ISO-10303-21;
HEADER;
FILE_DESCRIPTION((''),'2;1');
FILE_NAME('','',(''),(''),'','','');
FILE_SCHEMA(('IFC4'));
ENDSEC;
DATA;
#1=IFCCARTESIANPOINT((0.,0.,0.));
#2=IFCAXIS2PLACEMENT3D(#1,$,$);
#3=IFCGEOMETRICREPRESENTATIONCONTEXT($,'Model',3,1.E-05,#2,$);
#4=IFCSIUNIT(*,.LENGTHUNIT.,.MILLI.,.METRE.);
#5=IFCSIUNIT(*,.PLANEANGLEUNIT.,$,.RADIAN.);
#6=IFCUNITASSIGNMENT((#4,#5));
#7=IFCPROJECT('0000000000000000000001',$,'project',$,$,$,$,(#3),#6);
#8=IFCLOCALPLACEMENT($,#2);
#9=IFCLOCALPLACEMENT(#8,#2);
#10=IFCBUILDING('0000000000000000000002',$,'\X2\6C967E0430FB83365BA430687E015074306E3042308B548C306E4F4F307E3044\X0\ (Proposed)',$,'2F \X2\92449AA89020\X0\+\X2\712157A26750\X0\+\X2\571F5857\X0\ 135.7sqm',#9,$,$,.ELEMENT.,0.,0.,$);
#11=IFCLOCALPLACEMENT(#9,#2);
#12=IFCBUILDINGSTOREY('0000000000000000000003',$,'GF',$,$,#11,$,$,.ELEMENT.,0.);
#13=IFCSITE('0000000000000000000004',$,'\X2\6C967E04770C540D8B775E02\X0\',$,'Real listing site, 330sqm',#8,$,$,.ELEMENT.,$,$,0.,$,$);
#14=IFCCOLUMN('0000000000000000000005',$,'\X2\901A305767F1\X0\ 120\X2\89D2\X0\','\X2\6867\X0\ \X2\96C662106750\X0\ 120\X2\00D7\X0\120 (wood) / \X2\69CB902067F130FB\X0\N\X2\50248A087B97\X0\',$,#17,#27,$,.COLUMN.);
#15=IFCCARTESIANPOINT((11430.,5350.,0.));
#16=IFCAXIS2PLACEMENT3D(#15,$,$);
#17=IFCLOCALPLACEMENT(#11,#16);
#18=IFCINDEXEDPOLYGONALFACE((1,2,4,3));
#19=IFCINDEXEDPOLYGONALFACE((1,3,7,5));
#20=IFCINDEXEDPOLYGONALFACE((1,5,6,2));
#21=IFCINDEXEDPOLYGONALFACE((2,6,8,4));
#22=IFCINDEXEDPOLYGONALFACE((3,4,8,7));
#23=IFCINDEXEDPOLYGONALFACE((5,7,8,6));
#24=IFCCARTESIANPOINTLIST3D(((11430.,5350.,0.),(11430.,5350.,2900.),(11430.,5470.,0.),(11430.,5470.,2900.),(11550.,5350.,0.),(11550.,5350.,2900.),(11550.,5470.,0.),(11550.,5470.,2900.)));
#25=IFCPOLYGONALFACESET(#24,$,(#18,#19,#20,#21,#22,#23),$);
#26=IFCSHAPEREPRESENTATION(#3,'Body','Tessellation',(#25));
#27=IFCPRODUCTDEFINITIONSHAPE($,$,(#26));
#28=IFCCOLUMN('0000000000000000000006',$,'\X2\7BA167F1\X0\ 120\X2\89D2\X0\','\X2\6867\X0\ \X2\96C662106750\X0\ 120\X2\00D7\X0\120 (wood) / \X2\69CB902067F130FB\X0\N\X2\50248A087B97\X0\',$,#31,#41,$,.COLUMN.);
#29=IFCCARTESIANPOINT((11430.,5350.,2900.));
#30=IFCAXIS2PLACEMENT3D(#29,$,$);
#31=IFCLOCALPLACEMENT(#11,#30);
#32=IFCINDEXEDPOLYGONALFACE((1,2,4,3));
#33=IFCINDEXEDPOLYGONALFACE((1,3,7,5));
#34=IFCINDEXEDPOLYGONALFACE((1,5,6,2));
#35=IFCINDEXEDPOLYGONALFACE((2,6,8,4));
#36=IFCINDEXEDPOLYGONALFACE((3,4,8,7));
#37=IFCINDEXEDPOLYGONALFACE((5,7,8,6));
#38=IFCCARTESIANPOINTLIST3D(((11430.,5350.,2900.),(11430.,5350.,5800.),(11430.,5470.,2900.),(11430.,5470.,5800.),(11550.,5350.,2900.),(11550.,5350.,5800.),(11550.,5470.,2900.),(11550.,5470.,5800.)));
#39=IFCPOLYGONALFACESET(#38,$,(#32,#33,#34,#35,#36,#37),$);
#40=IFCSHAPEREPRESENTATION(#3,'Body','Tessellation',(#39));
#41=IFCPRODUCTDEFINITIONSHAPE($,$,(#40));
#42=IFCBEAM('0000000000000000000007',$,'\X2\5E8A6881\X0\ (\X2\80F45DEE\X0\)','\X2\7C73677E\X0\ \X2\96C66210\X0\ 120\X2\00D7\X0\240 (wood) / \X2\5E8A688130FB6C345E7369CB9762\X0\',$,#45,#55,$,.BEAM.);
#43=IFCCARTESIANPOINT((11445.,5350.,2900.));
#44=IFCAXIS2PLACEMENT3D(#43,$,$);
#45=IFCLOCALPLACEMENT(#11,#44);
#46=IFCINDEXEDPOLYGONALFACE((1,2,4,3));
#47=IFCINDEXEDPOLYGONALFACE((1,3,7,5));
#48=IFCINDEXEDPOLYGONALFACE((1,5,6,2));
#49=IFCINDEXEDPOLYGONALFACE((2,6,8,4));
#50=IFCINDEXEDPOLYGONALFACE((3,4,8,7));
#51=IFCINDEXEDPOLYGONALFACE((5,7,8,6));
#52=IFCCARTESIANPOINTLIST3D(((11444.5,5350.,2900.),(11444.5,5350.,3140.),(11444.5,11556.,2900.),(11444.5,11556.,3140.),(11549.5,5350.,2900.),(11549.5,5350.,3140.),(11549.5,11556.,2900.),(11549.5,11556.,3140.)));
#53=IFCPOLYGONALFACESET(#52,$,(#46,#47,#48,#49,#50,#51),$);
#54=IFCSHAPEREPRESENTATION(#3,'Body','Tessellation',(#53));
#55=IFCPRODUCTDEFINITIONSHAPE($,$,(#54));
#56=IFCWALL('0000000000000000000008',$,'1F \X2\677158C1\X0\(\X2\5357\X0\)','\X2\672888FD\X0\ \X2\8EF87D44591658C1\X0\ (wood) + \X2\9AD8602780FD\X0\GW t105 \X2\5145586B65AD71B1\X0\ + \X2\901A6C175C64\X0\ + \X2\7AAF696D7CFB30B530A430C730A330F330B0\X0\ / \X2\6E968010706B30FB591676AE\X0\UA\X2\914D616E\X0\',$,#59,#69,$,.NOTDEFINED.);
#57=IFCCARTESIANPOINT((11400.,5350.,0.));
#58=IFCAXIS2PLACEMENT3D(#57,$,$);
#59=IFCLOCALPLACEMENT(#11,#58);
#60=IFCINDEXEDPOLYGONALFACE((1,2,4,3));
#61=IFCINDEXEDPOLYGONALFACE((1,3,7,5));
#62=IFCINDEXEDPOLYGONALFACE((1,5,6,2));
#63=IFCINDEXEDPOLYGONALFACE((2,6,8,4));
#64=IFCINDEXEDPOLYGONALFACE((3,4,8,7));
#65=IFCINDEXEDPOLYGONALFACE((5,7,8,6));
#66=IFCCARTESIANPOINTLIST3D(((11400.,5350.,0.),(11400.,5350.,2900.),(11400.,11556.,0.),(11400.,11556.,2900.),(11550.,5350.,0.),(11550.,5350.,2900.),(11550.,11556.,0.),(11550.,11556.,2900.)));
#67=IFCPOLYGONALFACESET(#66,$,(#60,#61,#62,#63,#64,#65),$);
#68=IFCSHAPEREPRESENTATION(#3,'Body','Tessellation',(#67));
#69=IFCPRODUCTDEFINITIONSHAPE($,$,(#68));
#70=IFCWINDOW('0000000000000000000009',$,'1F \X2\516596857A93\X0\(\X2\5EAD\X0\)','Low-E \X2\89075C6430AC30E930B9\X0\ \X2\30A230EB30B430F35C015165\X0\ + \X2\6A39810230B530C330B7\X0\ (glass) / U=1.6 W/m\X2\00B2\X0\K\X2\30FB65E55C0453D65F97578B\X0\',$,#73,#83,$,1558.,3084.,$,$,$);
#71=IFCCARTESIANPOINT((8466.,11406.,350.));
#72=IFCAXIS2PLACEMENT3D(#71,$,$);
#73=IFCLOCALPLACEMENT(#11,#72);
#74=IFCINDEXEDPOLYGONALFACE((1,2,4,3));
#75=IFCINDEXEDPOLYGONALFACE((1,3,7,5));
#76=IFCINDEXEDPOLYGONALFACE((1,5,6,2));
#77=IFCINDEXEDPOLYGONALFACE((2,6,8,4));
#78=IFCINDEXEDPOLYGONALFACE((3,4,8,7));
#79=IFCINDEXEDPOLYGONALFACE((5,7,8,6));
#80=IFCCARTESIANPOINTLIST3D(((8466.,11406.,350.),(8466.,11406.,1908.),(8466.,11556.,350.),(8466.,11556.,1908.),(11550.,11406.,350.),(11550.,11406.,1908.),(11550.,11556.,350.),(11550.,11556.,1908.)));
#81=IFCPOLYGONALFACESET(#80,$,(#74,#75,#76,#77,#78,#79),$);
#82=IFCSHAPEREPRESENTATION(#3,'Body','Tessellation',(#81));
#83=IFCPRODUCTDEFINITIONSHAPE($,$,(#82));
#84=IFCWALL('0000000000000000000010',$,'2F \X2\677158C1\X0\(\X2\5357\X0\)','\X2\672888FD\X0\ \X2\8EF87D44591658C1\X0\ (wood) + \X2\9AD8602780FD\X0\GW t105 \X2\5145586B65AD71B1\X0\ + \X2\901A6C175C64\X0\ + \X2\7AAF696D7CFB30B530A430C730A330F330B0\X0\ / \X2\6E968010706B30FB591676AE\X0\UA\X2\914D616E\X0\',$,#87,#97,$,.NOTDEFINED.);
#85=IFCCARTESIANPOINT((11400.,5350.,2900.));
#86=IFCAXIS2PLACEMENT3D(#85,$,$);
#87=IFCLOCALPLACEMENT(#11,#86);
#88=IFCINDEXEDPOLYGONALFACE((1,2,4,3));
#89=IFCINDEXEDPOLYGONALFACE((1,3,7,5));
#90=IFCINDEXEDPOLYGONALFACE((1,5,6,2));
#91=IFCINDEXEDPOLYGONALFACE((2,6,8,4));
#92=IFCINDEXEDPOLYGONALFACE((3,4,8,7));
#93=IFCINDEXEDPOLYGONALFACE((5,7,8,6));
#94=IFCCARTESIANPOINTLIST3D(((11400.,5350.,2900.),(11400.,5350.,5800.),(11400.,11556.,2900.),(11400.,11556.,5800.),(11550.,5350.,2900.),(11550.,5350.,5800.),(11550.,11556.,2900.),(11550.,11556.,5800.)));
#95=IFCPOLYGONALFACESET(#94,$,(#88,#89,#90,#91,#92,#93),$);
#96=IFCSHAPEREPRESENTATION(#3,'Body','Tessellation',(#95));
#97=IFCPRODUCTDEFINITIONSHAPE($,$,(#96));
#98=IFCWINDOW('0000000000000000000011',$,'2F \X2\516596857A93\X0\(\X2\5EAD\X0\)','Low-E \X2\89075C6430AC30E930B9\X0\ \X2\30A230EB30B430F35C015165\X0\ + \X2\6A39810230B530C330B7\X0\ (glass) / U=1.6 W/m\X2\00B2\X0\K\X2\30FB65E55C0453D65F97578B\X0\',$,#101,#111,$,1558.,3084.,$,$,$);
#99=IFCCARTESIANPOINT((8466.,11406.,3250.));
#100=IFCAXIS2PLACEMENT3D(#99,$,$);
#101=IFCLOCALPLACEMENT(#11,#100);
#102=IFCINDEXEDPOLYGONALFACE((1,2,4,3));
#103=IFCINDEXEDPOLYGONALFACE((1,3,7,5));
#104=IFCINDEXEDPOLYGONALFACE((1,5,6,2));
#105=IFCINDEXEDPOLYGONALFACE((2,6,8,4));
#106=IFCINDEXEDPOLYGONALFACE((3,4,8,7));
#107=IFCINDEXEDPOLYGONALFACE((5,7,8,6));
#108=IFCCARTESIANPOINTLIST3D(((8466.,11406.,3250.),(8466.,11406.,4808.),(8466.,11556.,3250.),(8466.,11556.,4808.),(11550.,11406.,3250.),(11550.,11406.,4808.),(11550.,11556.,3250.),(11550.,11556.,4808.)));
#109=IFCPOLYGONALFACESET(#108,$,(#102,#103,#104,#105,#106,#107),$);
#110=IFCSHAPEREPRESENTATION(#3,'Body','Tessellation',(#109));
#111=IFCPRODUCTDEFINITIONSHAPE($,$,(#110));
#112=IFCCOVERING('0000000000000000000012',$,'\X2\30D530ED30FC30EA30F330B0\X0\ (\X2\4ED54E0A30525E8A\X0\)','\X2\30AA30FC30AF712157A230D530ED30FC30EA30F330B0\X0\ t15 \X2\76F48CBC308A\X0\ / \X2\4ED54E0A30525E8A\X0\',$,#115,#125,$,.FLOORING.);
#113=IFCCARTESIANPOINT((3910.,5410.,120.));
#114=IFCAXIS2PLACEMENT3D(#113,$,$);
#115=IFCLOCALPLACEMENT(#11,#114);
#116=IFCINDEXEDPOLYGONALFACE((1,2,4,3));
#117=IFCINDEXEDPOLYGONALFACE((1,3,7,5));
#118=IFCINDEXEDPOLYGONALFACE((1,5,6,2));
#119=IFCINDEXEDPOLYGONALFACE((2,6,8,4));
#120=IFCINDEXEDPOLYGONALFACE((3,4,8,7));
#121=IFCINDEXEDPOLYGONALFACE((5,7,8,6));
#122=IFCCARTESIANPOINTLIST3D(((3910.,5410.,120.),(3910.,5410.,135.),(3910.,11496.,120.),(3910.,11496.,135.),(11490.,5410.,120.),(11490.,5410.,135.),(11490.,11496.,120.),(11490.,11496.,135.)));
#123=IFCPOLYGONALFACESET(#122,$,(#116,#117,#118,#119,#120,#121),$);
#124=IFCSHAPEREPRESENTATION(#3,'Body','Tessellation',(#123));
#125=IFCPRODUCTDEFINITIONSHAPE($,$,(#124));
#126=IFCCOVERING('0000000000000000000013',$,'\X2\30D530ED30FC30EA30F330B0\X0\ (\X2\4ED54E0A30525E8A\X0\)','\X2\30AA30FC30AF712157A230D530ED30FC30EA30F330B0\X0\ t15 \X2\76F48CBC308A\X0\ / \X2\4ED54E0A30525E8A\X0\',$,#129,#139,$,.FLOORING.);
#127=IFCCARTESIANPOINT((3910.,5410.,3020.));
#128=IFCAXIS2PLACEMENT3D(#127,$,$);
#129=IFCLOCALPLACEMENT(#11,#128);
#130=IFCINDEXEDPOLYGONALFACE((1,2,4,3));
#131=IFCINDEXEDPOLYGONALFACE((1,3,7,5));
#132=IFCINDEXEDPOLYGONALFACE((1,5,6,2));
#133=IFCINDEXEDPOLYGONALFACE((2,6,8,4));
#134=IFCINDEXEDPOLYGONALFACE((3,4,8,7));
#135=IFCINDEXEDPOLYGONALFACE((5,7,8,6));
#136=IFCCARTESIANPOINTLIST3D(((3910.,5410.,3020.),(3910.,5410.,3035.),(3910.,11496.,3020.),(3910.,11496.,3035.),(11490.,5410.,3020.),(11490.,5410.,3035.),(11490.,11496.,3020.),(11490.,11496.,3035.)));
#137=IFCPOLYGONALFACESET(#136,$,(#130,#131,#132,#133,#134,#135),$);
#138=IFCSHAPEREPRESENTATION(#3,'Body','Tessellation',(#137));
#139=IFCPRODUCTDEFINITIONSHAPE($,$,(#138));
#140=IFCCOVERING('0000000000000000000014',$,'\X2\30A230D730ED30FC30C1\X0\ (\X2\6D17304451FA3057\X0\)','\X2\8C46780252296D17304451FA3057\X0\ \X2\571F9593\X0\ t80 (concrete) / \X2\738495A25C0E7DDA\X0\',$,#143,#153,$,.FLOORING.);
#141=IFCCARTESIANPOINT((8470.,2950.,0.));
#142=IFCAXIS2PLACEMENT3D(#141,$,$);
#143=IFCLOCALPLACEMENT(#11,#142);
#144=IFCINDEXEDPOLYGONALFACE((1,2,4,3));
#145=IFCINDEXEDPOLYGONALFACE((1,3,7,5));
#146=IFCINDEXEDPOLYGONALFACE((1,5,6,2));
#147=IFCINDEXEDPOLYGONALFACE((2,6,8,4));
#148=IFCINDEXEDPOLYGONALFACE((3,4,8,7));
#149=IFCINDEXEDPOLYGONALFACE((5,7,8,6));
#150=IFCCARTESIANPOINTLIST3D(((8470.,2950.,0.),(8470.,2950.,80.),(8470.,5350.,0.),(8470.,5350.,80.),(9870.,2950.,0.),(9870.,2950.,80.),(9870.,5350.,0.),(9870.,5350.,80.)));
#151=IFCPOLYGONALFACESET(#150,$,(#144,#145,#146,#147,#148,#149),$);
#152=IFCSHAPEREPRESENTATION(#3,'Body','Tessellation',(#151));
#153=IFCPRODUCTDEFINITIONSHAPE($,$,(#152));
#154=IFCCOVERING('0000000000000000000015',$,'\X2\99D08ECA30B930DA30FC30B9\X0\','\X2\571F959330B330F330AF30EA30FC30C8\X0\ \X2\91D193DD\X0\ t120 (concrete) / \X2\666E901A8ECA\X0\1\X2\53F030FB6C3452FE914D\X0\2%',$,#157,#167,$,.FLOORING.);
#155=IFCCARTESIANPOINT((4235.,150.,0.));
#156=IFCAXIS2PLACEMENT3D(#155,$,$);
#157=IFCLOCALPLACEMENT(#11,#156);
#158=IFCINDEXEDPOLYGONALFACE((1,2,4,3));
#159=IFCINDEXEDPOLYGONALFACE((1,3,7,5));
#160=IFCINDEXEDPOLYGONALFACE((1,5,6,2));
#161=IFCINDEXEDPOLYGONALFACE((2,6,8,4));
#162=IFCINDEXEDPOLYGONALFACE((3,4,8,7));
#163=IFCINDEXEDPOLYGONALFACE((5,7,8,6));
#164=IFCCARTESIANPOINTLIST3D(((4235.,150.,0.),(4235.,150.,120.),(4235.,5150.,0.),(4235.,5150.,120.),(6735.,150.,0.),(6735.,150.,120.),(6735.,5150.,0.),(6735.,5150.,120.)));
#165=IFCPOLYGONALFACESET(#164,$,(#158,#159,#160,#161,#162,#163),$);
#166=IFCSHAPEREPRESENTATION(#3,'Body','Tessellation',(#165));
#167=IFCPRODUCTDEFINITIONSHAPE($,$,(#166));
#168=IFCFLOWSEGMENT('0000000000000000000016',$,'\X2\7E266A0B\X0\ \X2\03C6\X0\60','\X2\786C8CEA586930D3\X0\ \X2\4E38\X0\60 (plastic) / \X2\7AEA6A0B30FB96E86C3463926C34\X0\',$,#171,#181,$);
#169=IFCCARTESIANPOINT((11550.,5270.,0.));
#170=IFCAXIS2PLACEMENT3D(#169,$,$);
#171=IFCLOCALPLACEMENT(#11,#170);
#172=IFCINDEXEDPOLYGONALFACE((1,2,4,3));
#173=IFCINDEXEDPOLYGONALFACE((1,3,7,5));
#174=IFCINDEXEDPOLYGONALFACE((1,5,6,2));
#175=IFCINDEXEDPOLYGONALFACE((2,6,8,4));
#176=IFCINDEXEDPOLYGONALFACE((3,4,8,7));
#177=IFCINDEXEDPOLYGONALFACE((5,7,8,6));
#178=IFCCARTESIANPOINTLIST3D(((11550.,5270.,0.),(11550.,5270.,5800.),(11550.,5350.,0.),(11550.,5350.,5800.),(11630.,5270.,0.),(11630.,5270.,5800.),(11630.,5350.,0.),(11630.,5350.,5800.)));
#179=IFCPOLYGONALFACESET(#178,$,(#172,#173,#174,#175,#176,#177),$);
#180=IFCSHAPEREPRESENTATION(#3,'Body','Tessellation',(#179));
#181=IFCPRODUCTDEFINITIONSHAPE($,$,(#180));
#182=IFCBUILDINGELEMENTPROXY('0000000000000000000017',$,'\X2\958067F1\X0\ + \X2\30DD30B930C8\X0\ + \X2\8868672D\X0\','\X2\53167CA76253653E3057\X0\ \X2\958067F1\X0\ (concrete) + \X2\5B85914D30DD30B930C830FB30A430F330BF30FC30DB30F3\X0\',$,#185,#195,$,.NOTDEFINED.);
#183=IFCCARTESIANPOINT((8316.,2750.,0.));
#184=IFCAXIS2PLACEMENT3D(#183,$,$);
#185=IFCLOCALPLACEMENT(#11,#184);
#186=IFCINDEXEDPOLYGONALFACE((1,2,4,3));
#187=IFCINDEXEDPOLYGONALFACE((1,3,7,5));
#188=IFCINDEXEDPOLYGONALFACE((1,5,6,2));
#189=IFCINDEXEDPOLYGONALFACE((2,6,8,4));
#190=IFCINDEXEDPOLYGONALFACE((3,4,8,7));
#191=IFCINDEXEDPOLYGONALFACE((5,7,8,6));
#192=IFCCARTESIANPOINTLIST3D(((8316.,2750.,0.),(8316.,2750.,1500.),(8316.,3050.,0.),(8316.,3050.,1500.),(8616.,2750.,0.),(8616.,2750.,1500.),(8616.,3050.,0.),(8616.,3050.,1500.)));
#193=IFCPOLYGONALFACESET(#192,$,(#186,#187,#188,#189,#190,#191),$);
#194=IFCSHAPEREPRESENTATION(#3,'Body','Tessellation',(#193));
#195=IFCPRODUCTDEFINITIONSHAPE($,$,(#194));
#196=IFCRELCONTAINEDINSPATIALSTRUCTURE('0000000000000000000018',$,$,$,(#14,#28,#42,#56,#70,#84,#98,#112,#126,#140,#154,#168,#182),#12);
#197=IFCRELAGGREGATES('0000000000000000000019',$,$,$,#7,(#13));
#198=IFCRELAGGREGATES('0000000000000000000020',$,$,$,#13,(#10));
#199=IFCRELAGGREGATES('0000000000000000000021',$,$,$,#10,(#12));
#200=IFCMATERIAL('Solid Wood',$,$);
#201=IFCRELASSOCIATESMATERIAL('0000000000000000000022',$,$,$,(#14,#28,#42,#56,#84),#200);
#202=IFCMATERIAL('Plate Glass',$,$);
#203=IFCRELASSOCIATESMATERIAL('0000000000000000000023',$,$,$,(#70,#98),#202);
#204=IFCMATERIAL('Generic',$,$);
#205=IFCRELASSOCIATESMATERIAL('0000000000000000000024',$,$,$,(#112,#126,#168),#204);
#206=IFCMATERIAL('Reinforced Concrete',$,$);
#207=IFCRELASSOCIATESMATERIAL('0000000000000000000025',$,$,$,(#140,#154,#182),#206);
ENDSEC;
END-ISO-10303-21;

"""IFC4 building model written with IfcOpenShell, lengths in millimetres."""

from ifc_helpers import new_model, si_unit, frame, frame_2d, origin, place, context, project, spatial, rectangle, extrude, material, element, fill, save


model = new_model("IFC4")

# Units and contexts
model_context = context("Model", 3, precision=1e-05, world=origin())
ifc_project = project(units=[si_unit("LENGTHUNIT", "METRE", prefix="MILLI"), si_unit("PLANEANGLEUNIT", "RADIAN")], contexts=[model_context])

# Site, building, storey
site_placement = place(None, origin())
site = spatial("IfcSite", under=ifc_project, at=site_placement, Name="沖縄県名護市", ObjectType="Real listing site, 330sqm", CompositionType="ELEMENT", RefElevation=0.0)
building_placement = place(site_placement, origin())
building = spatial("IfcBuilding", under=site, at=building_placement, Name="沖縄・茶室と縁側のある和の住まい (Proposed)", ObjectType="2F 鉄骨造+無垢材+土塗 135.7sqm", CompositionType="ELEMENT", ElevationOfRefHeight=0.0, ElevationOfTerrain=0.0)
storey_placement = place(building_placement, origin())
storey = spatial("IfcBuildingStorey", under=building, at=storey_placement, Name="GF", CompositionType="ELEMENT", Elevation=0.0)

# Columns
ifc_material_1 = material(Name="Solid Wood")
column_1_placement = place(storey_placement, frame((11430.0, 5350.0, 0.0)))
element("IfcColumn", 1, at=column_1_placement, inside=storey, material=ifc_material_1, Name="通し柱 120角", Description="桧 集成材 120×120 (wood) / 構造柱・N値計算", PredefinedType="COLUMN", context=model_context, shape_type="SweptSolid", body=[
    extrude(rectangle(XDim=120.0, YDim=120.0, at=frame_2d((60.0, 60.0))), frame((11430.0, 5350.0, 0.0)), (0.0, 0.0, 1.0), 2900.0),
])
column_2_placement = place(storey_placement, frame((11430.0, 5350.0, 2900.0)))
element("IfcColumn", 2, at=column_2_placement, inside=storey, material=ifc_material_1, Name="管柱 120角", Description="桧 集成材 120×120 (wood) / 構造柱・N値計算", PredefinedType="COLUMN", context=model_context, shape_type="SweptSolid", body=[
    extrude(rectangle(XDim=120.0, YDim=120.0, at=frame_2d((60.0, 60.0))), frame((11430.0, 5350.0, 2900.0)), (0.0, 0.0, 1.0), 2900.0),
])

# Beam
beam_1_placement = place(storey_placement, frame((11445.0, 5350.0, 2900.0)))
element("IfcBeam", 3, at=beam_1_placement, inside=storey, material=ifc_material_1, Name="床梁 (胴差)", Description="米松 集成 120×240 (wood) / 床梁・水平構面", PredefinedType="BEAM", context=model_context, shape_type="SweptSolid", body=[
    extrude(rectangle(XDim=105.0, YDim=6206.0, at=frame_2d((52.0, 3103.0))), frame((11445.0, 5350.0, 2900.0)), (0.0, 0.0, 1.0), 240.0),
])

# Wall, opening, window
wall_1_placement = place(storey_placement, frame((11400.0, 5350.0, 0.0)))
wall_1 = element("IfcWall", 4, at=wall_1_placement, inside=storey, material=ifc_material_1, Name="1F 東壁(南)", Description="木製 軸組外壁 (wood) + 高性能GW t105 充填断熱 + 通気層 + 窯業系サイディング / 準耐火・外皮UA配慮", PredefinedType="NOTDEFINED", context=model_context, shape_type="SweptSolid", body=[
    extrude(rectangle(XDim=150.0, YDim=6206.0, at=frame_2d((75.0, 3103.0))), frame((11400.0, 5350.0, 0.0)), (0.0, 0.0, 1.0), 2900.0),
])
opening_1_placement = place(storey_placement, frame((8466.0, 11406.0, 350.0)))
opening_1 = element("IfcOpeningElement", 5, at=opening_1_placement, cuts=wall_1, PredefinedType="NOTDEFINED", context=model_context, shape_type="SweptSolid", body=[
    extrude(rectangle(XDim=3084.0, YDim=150.0, at=frame_2d((1542.0, 75.0))), frame((8466.0, 11406.0, 350.0)), (0.0, 0.0, 1.0), 1558.0),
])
ifc_material_2 = material(Name="Plate Glass")
window_1_placement = place(storey_placement, frame((8466.0, 11406.0, 350.0)))
window_1 = element("IfcWindow", 6, at=window_1_placement, inside=storey, material=ifc_material_2, Name="1F 入隅窓(庭)", Description="Low-E 複層ガラス アルゴン封入 + 樹脂サッシ (glass) / U=1.6 W/m²K・日射取得型", OverallHeight=1558.0, OverallWidth=3084.0, context=model_context, shape_type="SweptSolid", body=[
    extrude(rectangle(XDim=3084.0, YDim=150.0, at=frame_2d((1542.0, 75.0))), frame((8466.0, 11406.0, 350.0)), (0.0, 0.0, 1.0), 1558.0),
])
fill(opening_1, window_1)

# Wall, opening, window
wall_2_placement = place(storey_placement, frame((11400.0, 5350.0, 2900.0)))
wall_2 = element("IfcWall", 7, at=wall_2_placement, inside=storey, material=ifc_material_1, Name="2F 東壁(南)", Description="木製 軸組外壁 (wood) + 高性能GW t105 充填断熱 + 通気層 + 窯業系サイディング / 準耐火・外皮UA配慮", PredefinedType="NOTDEFINED", context=model_context, shape_type="SweptSolid", body=[
    extrude(rectangle(XDim=150.0, YDim=6206.0, at=frame_2d((75.0, 3103.0))), frame((11400.0, 5350.0, 2900.0)), (0.0, 0.0, 1.0), 2900.0),
])
opening_2_placement = place(storey_placement, frame((8466.0, 11406.0, 3250.0)))
opening_2 = element("IfcOpeningElement", 8, at=opening_2_placement, cuts=wall_2, PredefinedType="NOTDEFINED", context=model_context, shape_type="SweptSolid", body=[
    extrude(rectangle(XDim=3084.0, YDim=150.0, at=frame_2d((1542.0, 75.0))), frame((8466.0, 11406.0, 3250.0)), (0.0, 0.0, 1.0), 1558.0),
])
window_2_placement = place(storey_placement, frame((8466.0, 11406.0, 3250.0)))
window_2 = element("IfcWindow", 9, at=window_2_placement, inside=storey, material=ifc_material_2, Name="2F 入隅窓(庭)", Description="Low-E 複層ガラス アルゴン封入 + 樹脂サッシ (glass) / U=1.6 W/m²K・日射取得型", OverallHeight=1558.0, OverallWidth=3084.0, context=model_context, shape_type="SweptSolid", body=[
    extrude(rectangle(XDim=3084.0, YDim=150.0, at=frame_2d((1542.0, 75.0))), frame((8466.0, 11406.0, 3250.0)), (0.0, 0.0, 1.0), 1558.0),
])
fill(opening_2, window_2)

# Coverings
ifc_material_3 = material(Name="Generic")
covering_1_placement = place(storey_placement, frame((3910.0, 5410.0, 120.0)))
element("IfcCovering", 10, at=covering_1_placement, inside=storey, material=ifc_material_3, Name="フローリング (仕上げ床)", Description="オーク無垢フローリング t15 直貼り / 仕上げ床", PredefinedType="FLOORING", context=model_context, shape_type="SweptSolid", body=[
    extrude(rectangle(XDim=7580.0, YDim=6086.0, at=frame_2d((3790.0, 3043.0))), frame((3910.0, 5410.0, 120.0)), (0.0, 0.0, 1.0), 15.0),
])
covering_2_placement = place(storey_placement, frame((3910.0, 5410.0, 3020.0)))
element("IfcCovering", 11, at=covering_2_placement, inside=storey, material=ifc_material_3, Name="フローリング (仕上げ床)", Description="オーク無垢フローリング t15 直貼り / 仕上げ床", PredefinedType="FLOORING", context=model_context, shape_type="SweptSolid", body=[
    extrude(rectangle(XDim=7580.0, YDim=6086.0, at=frame_2d((3790.0, 3043.0))), frame((3910.0, 5410.0, 3020.0)), (0.0, 0.0, 1.0), 15.0),
])
ifc_material_4 = material(Name="Reinforced Concrete")
covering_3_placement = place(storey_placement, frame((8470.0, 2950.0, 0.0)))
element("IfcCovering", 12, at=covering_3_placement, inside=storey, material=ifc_material_4, Name="アプローチ (洗い出し)", Description="豆砂利洗い出し 土間 t80 (concrete) / 玄関導線", PredefinedType="FLOORING", context=model_context, shape_type="SweptSolid", body=[
    extrude(rectangle(XDim=1400.0, YDim=2400.0, at=frame_2d((700.0, 1200.0))), frame((8470.0, 2950.0, 0.0)), (0.0, 0.0, 1.0), 80.0),
])
covering_4_placement = place(storey_placement, frame((4235.0, 150.0, 0.0)))
element("IfcCovering", 13, at=covering_4_placement, inside=storey, material=ifc_material_4, Name="駐車スペース", Description="土間コンクリート 金鏝 t120 (concrete) / 普通車1台・水勾配2%", PredefinedType="FLOORING", context=model_context, shape_type="SweptSolid", body=[
    extrude(rectangle(XDim=2500.0, YDim=5000.0, at=frame_2d((1250.0, 2500.0))), frame((4235.0, 150.0, 0.0)), (0.0, 0.0, 1.0), 120.0),
])

# Flow segment
flow_segment_placement = place(storey_placement, frame((11550.0, 5270.0, 0.0)))
element("IfcFlowSegment", 14, at=flow_segment_placement, inside=storey, material=ifc_material_3, Name="縦樋 φ60", Description="硬質塩ビ 丸60 (plastic) / 竪樋・雨水排水", context=model_context, shape_type="SweptSolid", body=[
    extrude(rectangle(XDim=80.0, YDim=80.0, at=frame_2d((40.0, 40.0))), frame((11550.0, 5270.0, 0.0)), (0.0, 0.0, 1.0), 5800.0),
])

# Building element proxy
proxy_placement = place(storey_placement, frame((8316.0, 2750.0, 0.0)))
element("IfcBuildingElementProxy", 15, at=proxy_placement, inside=storey, material=ifc_material_4, Name="門柱 + ポスト + 表札", Description="化粧打放し 門柱 (concrete) + 宅配ポスト・インターホン", PredefinedType="NOTDEFINED", context=model_context, shape_type="SweptSolid", body=[
    extrude(rectangle(XDim=300.0, YDim=300.0, at=frame_2d((150.0, 150.0))), frame((8316.0, 2750.0, 0.0)), (0.0, 0.0, 1.0), 1500.0),
])

save(model, "model.ifc")
